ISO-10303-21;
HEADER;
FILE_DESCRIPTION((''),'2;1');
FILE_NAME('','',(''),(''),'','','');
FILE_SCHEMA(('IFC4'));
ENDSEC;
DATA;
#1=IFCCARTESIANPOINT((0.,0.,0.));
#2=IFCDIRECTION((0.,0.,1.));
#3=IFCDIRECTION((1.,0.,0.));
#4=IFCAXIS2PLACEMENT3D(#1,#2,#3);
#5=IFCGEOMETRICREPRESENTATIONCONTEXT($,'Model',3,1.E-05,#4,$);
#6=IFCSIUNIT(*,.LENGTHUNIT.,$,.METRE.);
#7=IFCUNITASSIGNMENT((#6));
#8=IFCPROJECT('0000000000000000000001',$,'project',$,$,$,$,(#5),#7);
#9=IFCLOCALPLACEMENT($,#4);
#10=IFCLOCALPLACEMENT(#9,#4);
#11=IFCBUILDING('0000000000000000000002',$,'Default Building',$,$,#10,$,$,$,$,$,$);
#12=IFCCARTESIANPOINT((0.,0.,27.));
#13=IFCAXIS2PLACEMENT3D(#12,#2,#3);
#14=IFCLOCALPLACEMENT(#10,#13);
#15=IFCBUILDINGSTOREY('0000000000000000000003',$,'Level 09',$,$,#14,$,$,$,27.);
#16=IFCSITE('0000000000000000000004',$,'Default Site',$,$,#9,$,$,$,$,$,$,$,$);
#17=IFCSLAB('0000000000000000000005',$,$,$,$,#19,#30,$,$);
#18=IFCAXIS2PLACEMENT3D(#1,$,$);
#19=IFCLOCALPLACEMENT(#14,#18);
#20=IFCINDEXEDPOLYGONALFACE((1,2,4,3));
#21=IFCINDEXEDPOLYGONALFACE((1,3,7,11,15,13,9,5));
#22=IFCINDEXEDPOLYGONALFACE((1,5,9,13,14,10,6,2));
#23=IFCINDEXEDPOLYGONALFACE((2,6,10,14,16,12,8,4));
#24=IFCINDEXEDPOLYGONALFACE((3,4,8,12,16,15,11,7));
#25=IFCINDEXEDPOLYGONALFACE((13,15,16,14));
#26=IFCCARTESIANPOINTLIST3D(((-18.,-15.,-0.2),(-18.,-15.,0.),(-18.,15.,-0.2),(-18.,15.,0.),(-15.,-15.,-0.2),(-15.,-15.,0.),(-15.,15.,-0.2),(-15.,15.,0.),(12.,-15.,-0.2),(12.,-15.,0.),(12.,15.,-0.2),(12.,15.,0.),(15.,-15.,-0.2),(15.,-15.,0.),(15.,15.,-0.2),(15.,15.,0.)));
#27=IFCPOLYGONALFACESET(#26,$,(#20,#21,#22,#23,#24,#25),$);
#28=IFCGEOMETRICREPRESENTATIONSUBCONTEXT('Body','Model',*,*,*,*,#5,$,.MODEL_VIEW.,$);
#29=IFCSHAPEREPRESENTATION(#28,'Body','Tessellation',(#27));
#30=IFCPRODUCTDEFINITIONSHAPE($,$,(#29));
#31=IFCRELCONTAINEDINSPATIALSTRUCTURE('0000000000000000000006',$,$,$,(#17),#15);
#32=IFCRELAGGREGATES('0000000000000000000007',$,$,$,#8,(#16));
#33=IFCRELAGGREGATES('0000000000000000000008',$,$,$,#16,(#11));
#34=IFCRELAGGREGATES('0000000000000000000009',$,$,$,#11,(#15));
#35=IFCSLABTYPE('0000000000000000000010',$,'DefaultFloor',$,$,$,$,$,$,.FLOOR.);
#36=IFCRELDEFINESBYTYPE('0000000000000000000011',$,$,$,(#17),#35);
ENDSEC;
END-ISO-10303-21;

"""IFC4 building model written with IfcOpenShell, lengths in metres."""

from ifc_helpers import new_model, si_unit, frame, origin_with_axes, place, context, subcontext, project, spatial, polyline, outline, extrude, type_object, element, save


model = new_model("IFC4")

# Units and contexts
model_context = context("Model", 3, precision=1e-05, world=origin_with_axes())
body_context = subcontext(model_context, "Body", "Model", "MODEL_VIEW")
ifc_project = project(units=[si_unit("LENGTHUNIT", "METRE")], contexts=[model_context])

# Site, building, storey
site_placement = place(None, origin_with_axes())
site = spatial("IfcSite", under=ifc_project, at=site_placement, Name="Default Site")
building_placement = place(site_placement, origin_with_axes())
building = spatial("IfcBuilding", under=site, at=building_placement, Name="Default Building")
storey_placement = place(building_placement, frame((0.0, 0.0, 27.0), z_axis=(0.0, 0.0, 1.0), x_axis=(1.0, 0.0, 0.0)))
storey = spatial("IfcBuildingStorey", under=building, at=storey_placement, Name="Level 09", Elevation=27.0)

# Slab
slab_type = type_object("IfcSlabType", Name="DefaultFloor", PredefinedType="FLOOR")
slab_placement = place(storey_placement, frame((0.0, 0.0, -27.0), z_axis=(0.0, 0.0, 1.0), x_axis=(1.0, 0.0, 0.0)))
element("IfcSlab", 1, at=slab_placement, inside=storey, type_object=slab_type, context=body_context, shape_type="SweptSolid", body=[
    extrude(outline(polyline([(-18.0, -15.0), (-18.0, 15.0), (-15.0, 15.0), (12.0, 15.0), (15.0, 15.0), (15.0, -15.0), (12.0, -15.0), (-15.0, -15.0), (-18.0, -15.0)])), frame((0.0, 0.0, 27.0), z_axis=(0.0, 0.0, 1.0), x_axis=(1.0, 0.0, 0.0)), (0.0, 0.0, -1.0), 0.2),
])

save(model, "model.ifc")
